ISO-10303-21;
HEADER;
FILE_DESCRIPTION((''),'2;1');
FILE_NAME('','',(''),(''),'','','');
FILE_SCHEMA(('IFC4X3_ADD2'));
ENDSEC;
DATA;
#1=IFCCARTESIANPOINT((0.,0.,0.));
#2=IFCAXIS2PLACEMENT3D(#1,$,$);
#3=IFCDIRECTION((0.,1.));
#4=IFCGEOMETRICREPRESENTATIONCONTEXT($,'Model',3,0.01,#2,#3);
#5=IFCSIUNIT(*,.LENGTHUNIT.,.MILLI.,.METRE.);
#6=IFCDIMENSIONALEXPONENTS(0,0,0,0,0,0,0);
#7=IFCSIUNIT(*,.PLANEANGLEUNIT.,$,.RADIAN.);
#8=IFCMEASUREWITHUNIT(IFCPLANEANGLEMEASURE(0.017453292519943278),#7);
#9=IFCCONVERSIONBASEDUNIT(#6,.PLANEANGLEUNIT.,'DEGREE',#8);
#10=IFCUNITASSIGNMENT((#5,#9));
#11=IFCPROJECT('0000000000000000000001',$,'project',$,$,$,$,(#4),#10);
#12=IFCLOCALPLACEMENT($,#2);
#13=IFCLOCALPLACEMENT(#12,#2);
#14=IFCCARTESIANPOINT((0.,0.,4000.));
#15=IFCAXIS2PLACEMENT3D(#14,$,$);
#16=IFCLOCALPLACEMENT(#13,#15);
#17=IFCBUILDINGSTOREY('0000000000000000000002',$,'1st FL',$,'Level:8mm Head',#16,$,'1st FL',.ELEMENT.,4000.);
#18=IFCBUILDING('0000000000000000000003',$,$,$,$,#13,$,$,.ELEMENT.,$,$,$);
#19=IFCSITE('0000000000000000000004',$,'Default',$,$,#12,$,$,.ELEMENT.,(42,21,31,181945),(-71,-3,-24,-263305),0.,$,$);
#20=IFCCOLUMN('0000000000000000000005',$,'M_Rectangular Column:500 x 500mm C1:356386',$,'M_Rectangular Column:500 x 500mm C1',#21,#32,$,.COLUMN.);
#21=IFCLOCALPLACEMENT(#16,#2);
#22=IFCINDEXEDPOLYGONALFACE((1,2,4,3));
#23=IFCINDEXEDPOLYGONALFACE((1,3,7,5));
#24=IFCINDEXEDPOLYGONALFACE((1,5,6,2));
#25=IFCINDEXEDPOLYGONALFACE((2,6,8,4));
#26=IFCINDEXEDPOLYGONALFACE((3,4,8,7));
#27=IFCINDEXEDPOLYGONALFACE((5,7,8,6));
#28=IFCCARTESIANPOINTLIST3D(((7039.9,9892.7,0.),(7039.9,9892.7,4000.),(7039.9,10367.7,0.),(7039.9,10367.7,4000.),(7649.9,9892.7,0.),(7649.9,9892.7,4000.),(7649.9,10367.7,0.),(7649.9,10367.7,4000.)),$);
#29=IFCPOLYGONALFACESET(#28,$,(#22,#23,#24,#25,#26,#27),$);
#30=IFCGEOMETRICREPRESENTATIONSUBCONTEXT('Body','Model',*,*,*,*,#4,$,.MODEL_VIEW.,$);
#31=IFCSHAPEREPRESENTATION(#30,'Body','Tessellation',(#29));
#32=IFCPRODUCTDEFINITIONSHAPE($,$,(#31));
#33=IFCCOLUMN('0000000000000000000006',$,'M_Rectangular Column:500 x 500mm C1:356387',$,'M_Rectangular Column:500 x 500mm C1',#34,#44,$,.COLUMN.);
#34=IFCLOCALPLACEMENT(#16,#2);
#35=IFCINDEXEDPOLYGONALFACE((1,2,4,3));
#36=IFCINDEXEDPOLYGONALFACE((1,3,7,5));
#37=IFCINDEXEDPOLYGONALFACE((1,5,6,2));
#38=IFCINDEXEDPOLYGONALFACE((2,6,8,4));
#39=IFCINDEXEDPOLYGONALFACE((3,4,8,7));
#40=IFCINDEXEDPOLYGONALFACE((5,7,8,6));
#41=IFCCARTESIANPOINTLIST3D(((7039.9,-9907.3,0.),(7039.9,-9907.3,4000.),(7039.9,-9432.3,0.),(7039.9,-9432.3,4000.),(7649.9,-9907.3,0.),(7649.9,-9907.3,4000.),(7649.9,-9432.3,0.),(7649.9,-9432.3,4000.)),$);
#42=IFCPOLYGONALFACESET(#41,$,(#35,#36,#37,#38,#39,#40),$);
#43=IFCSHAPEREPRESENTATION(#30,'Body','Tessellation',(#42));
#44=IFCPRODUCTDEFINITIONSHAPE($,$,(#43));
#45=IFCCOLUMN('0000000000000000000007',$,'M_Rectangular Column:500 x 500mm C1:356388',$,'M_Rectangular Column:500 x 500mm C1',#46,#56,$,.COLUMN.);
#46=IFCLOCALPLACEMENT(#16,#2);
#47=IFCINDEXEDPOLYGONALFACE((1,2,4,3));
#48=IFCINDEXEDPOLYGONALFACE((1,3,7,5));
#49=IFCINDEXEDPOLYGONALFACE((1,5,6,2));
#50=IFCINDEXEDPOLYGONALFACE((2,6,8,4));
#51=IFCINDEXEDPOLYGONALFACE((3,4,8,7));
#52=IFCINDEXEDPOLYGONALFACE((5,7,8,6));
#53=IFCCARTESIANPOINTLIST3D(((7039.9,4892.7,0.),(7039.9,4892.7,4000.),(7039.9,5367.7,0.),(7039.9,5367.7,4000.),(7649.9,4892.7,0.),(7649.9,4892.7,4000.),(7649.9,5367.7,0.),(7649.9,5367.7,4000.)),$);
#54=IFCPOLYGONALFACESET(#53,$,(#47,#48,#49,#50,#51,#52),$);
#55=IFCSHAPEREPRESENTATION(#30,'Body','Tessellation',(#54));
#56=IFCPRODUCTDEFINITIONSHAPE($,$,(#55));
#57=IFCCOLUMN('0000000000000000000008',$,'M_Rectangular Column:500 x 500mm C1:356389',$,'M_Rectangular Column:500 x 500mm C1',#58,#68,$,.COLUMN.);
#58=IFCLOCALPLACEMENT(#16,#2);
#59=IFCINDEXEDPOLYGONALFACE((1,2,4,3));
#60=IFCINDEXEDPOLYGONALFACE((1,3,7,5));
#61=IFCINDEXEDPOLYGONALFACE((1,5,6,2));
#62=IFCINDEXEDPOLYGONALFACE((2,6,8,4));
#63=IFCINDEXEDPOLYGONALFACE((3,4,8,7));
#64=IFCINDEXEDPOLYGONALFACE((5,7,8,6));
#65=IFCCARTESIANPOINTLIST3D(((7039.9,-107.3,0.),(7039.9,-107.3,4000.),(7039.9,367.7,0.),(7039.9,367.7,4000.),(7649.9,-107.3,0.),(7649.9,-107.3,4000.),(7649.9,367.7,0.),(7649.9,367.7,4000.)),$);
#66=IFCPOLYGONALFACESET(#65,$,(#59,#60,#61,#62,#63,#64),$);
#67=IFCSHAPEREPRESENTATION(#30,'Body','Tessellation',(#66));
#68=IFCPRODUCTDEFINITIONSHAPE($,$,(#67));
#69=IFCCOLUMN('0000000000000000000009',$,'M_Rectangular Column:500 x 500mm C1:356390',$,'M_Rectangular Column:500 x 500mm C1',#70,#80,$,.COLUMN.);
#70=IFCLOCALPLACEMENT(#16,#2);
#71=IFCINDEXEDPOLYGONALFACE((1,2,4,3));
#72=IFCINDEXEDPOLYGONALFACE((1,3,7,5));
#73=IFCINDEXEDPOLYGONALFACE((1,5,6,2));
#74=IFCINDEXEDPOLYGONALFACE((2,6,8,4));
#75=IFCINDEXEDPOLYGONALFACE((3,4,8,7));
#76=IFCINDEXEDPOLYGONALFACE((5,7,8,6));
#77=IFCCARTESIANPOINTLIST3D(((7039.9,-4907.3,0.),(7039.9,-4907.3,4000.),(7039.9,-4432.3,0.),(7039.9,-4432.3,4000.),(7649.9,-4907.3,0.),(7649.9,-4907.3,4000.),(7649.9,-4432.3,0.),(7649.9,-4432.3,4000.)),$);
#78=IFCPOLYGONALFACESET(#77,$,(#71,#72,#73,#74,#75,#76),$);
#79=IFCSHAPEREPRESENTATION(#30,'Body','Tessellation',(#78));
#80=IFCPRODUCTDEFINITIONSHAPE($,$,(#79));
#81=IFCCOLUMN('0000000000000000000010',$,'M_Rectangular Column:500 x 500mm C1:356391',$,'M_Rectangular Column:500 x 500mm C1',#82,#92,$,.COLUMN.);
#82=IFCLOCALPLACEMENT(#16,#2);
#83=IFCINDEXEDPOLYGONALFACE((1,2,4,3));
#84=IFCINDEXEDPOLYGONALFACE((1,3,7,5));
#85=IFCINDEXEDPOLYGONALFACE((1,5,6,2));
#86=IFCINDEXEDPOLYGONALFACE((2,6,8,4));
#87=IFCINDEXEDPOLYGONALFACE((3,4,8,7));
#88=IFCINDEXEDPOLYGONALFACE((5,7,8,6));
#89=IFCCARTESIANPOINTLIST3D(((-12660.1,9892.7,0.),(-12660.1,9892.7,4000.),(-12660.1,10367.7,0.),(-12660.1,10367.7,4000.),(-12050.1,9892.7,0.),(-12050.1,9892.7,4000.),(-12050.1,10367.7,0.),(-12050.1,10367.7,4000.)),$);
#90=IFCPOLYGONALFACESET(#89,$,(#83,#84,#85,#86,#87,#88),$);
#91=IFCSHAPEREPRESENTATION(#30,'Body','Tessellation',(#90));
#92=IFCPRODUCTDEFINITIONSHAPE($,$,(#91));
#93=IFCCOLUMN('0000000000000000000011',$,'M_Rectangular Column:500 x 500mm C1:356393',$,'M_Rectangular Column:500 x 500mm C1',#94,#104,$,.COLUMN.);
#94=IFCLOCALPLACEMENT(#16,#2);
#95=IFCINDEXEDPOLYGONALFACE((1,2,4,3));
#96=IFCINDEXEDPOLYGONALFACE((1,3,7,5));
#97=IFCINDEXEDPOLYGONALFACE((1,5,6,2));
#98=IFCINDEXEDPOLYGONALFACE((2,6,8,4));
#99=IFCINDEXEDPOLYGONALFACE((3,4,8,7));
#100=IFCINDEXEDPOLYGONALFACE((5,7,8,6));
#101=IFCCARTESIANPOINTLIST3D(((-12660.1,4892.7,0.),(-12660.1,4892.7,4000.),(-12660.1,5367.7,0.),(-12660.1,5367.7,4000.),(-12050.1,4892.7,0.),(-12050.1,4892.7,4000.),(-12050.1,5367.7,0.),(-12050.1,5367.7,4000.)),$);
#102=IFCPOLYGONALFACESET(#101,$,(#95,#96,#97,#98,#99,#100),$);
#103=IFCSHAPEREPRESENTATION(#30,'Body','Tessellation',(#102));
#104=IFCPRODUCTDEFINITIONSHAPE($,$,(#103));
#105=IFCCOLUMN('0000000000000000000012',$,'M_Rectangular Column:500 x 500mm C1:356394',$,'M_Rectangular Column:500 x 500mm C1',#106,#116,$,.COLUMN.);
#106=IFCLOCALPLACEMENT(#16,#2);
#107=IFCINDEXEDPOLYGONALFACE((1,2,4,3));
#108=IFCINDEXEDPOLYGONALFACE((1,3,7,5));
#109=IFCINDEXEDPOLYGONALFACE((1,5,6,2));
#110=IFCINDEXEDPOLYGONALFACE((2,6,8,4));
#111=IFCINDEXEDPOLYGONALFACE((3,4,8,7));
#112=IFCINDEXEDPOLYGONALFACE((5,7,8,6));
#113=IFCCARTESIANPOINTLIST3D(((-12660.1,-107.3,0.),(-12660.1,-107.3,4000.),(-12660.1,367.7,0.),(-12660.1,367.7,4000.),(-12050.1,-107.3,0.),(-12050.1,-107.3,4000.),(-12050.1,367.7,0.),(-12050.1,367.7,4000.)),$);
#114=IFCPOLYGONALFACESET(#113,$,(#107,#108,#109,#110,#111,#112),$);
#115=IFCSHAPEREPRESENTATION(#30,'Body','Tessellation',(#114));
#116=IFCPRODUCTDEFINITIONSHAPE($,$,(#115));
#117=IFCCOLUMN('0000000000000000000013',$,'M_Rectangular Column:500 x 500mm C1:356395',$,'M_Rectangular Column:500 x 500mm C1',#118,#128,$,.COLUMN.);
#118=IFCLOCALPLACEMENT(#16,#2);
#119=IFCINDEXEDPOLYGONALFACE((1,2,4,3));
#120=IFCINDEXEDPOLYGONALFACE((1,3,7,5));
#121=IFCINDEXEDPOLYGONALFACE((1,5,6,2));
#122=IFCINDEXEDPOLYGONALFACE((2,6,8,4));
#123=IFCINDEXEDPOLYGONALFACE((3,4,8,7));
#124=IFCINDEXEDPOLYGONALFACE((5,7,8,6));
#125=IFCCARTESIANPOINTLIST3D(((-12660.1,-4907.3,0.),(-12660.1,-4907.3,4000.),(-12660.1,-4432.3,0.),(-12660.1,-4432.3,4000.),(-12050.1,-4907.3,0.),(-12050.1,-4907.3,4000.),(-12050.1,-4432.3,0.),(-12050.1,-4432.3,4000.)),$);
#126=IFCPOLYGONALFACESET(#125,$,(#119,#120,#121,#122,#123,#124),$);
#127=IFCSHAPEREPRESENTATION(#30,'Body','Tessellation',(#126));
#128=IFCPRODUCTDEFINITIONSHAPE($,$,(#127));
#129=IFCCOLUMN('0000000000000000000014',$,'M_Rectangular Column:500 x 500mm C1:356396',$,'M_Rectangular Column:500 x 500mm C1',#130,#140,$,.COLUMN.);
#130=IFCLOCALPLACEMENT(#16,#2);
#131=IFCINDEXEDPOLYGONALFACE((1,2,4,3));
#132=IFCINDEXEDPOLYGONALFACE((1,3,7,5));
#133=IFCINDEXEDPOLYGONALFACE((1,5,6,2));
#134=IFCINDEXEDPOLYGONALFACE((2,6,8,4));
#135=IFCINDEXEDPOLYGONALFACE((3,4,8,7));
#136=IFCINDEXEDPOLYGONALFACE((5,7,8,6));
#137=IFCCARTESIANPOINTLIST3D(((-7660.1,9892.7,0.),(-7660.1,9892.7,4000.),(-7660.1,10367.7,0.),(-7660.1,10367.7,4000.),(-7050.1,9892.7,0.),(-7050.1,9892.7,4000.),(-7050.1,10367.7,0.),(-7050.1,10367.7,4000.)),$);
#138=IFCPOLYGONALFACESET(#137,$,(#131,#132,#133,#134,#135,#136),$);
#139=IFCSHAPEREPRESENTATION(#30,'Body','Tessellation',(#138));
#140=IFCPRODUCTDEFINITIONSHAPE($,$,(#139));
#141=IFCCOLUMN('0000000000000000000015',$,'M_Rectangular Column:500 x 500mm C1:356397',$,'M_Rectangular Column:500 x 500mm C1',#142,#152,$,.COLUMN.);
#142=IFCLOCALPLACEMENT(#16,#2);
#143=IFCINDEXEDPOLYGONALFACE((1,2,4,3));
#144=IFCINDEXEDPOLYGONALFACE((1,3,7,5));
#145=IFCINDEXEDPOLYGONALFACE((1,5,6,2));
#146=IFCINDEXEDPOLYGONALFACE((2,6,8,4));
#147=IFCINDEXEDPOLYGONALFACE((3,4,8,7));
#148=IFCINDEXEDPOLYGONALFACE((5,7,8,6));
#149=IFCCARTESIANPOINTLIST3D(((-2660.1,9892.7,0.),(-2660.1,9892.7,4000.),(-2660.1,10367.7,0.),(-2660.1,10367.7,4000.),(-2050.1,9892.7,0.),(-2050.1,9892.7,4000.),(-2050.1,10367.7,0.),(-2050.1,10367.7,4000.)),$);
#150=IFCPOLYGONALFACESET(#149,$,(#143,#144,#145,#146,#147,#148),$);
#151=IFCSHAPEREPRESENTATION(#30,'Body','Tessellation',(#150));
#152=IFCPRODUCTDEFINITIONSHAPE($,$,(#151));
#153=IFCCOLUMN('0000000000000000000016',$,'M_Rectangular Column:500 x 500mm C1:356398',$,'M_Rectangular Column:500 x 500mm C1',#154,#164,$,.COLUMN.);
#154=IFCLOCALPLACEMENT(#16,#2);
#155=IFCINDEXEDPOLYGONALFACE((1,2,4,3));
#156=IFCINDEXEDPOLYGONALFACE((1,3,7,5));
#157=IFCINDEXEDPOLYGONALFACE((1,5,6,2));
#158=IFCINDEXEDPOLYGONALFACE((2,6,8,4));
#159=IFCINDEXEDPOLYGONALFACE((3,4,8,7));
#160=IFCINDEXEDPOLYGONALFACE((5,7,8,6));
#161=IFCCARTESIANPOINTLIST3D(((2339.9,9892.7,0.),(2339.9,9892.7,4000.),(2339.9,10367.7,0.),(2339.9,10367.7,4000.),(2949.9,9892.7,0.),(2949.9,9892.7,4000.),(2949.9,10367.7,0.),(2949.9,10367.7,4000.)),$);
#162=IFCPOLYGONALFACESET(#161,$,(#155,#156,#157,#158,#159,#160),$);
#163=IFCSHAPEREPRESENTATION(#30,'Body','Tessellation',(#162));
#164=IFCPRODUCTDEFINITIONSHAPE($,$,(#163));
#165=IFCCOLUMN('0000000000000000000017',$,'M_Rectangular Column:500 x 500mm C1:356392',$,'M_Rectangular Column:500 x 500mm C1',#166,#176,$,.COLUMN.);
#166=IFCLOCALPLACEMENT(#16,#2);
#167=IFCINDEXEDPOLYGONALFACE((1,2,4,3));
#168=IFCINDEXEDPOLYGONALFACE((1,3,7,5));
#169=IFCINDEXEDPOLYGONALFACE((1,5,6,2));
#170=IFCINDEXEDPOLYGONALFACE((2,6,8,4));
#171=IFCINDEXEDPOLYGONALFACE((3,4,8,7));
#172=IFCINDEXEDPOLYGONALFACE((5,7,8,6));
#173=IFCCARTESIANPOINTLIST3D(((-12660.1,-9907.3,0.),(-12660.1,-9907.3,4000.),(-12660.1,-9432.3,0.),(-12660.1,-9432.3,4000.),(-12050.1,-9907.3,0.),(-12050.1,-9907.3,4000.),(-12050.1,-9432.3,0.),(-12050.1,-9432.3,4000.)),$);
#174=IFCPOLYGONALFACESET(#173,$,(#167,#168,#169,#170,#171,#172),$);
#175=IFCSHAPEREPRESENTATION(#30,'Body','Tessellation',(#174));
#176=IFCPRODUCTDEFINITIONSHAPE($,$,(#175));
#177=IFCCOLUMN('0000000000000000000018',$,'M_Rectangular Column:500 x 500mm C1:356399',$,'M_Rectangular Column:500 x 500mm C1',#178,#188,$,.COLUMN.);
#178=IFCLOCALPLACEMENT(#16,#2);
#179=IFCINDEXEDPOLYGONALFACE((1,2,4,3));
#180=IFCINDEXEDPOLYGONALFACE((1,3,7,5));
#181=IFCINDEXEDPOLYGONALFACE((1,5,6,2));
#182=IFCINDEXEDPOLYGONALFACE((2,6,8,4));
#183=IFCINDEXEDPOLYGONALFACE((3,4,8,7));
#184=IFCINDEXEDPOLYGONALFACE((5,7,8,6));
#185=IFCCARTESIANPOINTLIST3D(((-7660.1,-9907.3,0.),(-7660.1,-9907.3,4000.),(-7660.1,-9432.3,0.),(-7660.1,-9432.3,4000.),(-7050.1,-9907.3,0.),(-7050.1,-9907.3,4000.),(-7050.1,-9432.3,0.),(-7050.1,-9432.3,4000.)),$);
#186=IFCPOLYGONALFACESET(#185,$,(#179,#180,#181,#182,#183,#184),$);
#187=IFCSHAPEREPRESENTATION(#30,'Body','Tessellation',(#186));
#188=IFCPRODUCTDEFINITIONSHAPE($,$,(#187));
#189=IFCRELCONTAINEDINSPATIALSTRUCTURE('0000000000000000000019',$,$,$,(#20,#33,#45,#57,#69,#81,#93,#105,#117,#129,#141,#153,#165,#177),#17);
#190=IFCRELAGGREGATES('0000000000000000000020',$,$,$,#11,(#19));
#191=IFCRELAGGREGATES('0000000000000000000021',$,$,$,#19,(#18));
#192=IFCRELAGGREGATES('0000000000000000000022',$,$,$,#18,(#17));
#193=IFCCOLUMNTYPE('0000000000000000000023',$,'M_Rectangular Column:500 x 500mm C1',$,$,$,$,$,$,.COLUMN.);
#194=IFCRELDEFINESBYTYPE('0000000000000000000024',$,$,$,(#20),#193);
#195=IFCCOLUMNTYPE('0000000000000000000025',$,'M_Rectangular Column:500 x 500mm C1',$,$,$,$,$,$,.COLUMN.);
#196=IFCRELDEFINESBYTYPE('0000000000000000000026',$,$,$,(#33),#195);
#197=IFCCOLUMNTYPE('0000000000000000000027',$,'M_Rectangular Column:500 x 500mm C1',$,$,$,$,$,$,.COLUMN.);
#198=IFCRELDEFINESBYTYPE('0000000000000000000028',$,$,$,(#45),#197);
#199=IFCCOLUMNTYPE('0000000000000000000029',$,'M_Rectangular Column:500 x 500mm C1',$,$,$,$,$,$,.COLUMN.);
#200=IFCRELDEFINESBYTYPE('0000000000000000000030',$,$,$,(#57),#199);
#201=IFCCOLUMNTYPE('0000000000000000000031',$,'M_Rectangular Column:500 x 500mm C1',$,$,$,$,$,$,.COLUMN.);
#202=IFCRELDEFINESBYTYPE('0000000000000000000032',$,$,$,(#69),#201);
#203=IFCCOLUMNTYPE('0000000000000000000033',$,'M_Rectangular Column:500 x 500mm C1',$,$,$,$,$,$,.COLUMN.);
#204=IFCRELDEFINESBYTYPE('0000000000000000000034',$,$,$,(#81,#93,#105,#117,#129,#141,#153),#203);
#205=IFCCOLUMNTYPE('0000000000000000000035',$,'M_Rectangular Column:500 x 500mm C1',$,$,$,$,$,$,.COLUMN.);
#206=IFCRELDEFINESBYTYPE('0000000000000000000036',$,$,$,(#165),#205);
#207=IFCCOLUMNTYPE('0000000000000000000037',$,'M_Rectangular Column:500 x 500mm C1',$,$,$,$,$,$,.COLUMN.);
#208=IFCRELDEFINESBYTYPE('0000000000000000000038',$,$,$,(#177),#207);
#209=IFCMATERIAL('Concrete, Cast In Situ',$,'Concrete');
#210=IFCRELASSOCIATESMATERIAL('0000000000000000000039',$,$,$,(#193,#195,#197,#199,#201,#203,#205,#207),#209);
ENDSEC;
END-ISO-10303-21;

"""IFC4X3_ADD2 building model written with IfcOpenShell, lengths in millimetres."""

from ifc_helpers import new_model, entity, si_unit, converted_unit, direction, frame, frame_2d, origin, origin_2d_with_axis, place, context, subcontext, project, spatial, rectangle, extrude, source, transform, mapped, material, material_profile, profile_set, type_object, type_shapes, element, save


model = new_model("IFC4X3_ADD2")

# Units and contexts
model_context = context("Model", 3, precision=0.01, world=origin(), true_north=direction((0.0, 1.0)))
body_context = subcontext(model_context, "Body", "Model", "MODEL_VIEW")
ifc_project = project(units=[si_unit("LENGTHUNIT", "METRE", prefix="MILLI"), converted_unit("PLANEANGLEUNIT", "DEGREE", entity("IfcPlaneAngleMeasure", 0.017453292519943278), si_unit("PLANEANGLEUNIT", "RADIAN"), dimensions=[0, 0, 0, 0, 0, 0, 0])], contexts=[model_context])

# Site, building, storey
site_placement = place(None, origin())
site = spatial("IfcSite", under=ifc_project, at=site_placement, Name="Default", CompositionType="ELEMENT", RefLatitude=(42, 21, 31, 181945), RefLongitude=(-71, -3, -24, -263305), RefElevation=0.0)
building_placement = place(site_placement, origin())
building = spatial("IfcBuilding", under=site, at=building_placement, CompositionType="ELEMENT")
storey_placement = place(building_placement, frame((0.0, 0.0, 4000.0)))
storey = spatial("IfcBuildingStorey", under=building, at=storey_placement, Name="1st FL", ObjectType="Level:8mm Head", LongName="1st FL", CompositionType="ELEMENT", Elevation=4000.0)

# Columns
ifc_material_1 = material(Name="Concrete, Cast In Situ", Category="Concrete")
ifc_material_profile_1 = material_profile(ifc_material_1, rectangle(XDim=610.0, YDim=475.0, at=frame_2d((0.0, 0.0), x_axis=(1.0, 0.0))), Name="500 x 500mm C1")
ifc_profile_set_1 = profile_set([ifc_material_profile_1], Name="500 x 500mm C1")
column_type_1 = type_object("IfcColumnType", Name="M_Rectangular Column:500 x 500mm C1", PredefinedType="COLUMN", material=ifc_profile_set_1)
shared_shape_1 = source(origin(), body_context, "Body", "SweptSolid", [
    extrude(rectangle(XDim=610.0, YDim=475.0, at=frame_2d((0.0, 0.0), x_axis=(1.0, 0.0))), frame((7344.9, 10130.2, 4000.0), z_axis=(0.0, 0.0, 1.0), x_axis=(-1.0, 0.0, 0.0)), (0.0, 0.0, 1.0), 4000.0),
])
type_shapes(column_type_1, [shared_shape_1])
column_1_placement = place(storey_placement, frame((0.0, 0.0, -4000.0)))
element("IfcColumn", 1, at=column_1_placement, inside=storey, type_object=column_type_1, Name="M_Rectangular Column:500 x 500mm C1:356386", ObjectType="M_Rectangular Column:500 x 500mm C1", PredefinedType="COLUMN", context=body_context, shape_type="MappedRepresentation", body=[
    mapped(shared_shape_1, transform((0.0, 0.0, 0.0), scale=1.0)),
])
column_type_2 = type_object("IfcColumnType", Name="M_Rectangular Column:500 x 500mm C1", PredefinedType="COLUMN", material=ifc_profile_set_1)
shared_shape_2 = source(origin(), body_context, "Body", "SweptSolid", [
    extrude(rectangle(XDim=610.0, YDim=475.0, at=origin_2d_with_axis()), frame((7344.9, -9669.8, 4000.0), z_axis=(0.0, 0.0, 1.0), x_axis=(-1.0, 0.0, 0.0)), (0.0, 0.0, 1.0), 4000.0),
])
type_shapes(column_type_2, [shared_shape_2])
column_2_placement = place(storey_placement, frame((0.0, 0.0, -4000.0)))
element("IfcColumn", 2, at=column_2_placement, inside=storey, type_object=column_type_2, Name="M_Rectangular Column:500 x 500mm C1:356387", ObjectType="M_Rectangular Column:500 x 500mm C1", PredefinedType="COLUMN", context=body_context, shape_type="MappedRepresentation", body=[
    mapped(shared_shape_2, transform((0.0, 0.0, 0.0), scale=1.0)),
])
column_type_3 = type_object("IfcColumnType", Name="M_Rectangular Column:500 x 500mm C1", PredefinedType="COLUMN", material=ifc_profile_set_1)
shared_shape_3 = source(origin(), body_context, "Body", "SweptSolid", [
    extrude(rectangle(XDim=610.0, YDim=475.0, at=frame_2d((0.0, 0.0), x_axis=(1.0, 0.0))), frame((7344.9, 5130.2, 4000.0), z_axis=(0.0, 0.0, 1.0), x_axis=(-1.0, 0.0, 0.0)), (0.0, 0.0, 1.0), 4000.0),
])
type_shapes(column_type_3, [shared_shape_3])
column_3_placement = place(storey_placement, frame((0.0, 0.0, -4000.0)))
element("IfcColumn", 3, at=column_3_placement, inside=storey, type_object=column_type_3, Name="M_Rectangular Column:500 x 500mm C1:356388", ObjectType="M_Rectangular Column:500 x 500mm C1", PredefinedType="COLUMN", context=body_context, shape_type="MappedRepresentation", body=[
    mapped(shared_shape_3, transform((0.0, 0.0, 0.0), scale=1.0)),
])
column_type_4 = type_object("IfcColumnType", Name="M_Rectangular Column:500 x 500mm C1", PredefinedType="COLUMN", material=ifc_profile_set_1)
shared_shape_4 = source(origin(), body_context, "Body", "SweptSolid", [
    extrude(rectangle(XDim=610.0, YDim=475.0, at=origin_2d_with_axis()), frame((7344.9, 130.2, 4000.0), z_axis=(0.0, 0.0, 1.0), x_axis=(-1.0, 0.0, 0.0)), (0.0, 0.0, 1.0), 4000.0),
])
type_shapes(column_type_4, [shared_shape_4])
column_4_placement = place(storey_placement, frame((0.0, 0.0, -4000.0)))
element("IfcColumn", 4, at=column_4_placement, inside=storey, type_object=column_type_4, Name="M_Rectangular Column:500 x 500mm C1:356389", ObjectType="M_Rectangular Column:500 x 500mm C1", PredefinedType="COLUMN", context=body_context, shape_type="MappedRepresentation", body=[
    mapped(shared_shape_4, transform((0.0, 0.0, 0.0), scale=1.0)),
])
column_type_5 = type_object("IfcColumnType", Name="M_Rectangular Column:500 x 500mm C1", PredefinedType="COLUMN", material=ifc_profile_set_1)
shared_shape_5 = source(origin(), body_context, "Body", "SweptSolid", [
    extrude(rectangle(XDim=610.0, YDim=475.0, at=origin_2d_with_axis()), frame((7344.9, -4669.8, 4000.0), z_axis=(0.0, 0.0, 1.0), x_axis=(-1.0, 0.0, 0.0)), (0.0, 0.0, 1.0), 4000.0),
])
type_shapes(column_type_5, [shared_shape_5])
column_5_placement = place(storey_placement, frame((0.0, 0.0, -4000.0)))
element("IfcColumn", 5, at=column_5_placement, inside=storey, type_object=column_type_5, Name="M_Rectangular Column:500 x 500mm C1:356390", ObjectType="M_Rectangular Column:500 x 500mm C1", PredefinedType="COLUMN", context=body_context, shape_type="MappedRepresentation", body=[
    mapped(shared_shape_5, transform((0.0, 0.0, 0.0), scale=1.0)),
])
column_type_6 = type_object("IfcColumnType", Name="M_Rectangular Column:500 x 500mm C1", PredefinedType="COLUMN", material=ifc_profile_set_1)
shared_shape_6 = source(origin(), body_context, "Body", "SweptSolid", [
    extrude(rectangle(XDim=610.0, YDim=475.0, at=origin_2d_with_axis()), frame((0.0, 0.0, 4000.0), z_axis=(0.0, 0.0, 1.0), x_axis=(-1.0, 0.0, 0.0)), (0.0, 0.0, 1.0), 4000.0),
])
type_shapes(column_type_6, [shared_shape_6])
for number, where, name in (
    (6, (-12355.1, 10130.2, -4000.0), "M_Rectangular Column:500 x 500mm C1:356391"),
    (7, (-12355.1, 5130.2, -4000.0), "M_Rectangular Column:500 x 500mm C1:356393"),
    (8, (-12355.1, 130.2, -4000.0), "M_Rectangular Column:500 x 500mm C1:356394"),
    (9, (-12355.1, -4669.8, -4000.0), "M_Rectangular Column:500 x 500mm C1:356395"),
    (10, (-7355.1, 10130.2, -4000.0), "M_Rectangular Column:500 x 500mm C1:356396"),
    (11, (-2355.1, 10130.2, -4000.0), "M_Rectangular Column:500 x 500mm C1:356397"),
    (12, (2644.9, 10130.2, -4000.0), "M_Rectangular Column:500 x 500mm C1:356398"),
):
    element("IfcColumn", number, at=place(storey_placement, frame(where)), inside=storey, type_object=column_type_6, Name=name, ObjectType="M_Rectangular Column:500 x 500mm C1", PredefinedType="COLUMN", context=body_context, shape_type="MappedRepresentation", body=[
        mapped(shared_shape_6, transform((0.0, 0.0, 0.0), scale=1.0)),
    ])
column_type_7 = type_object("IfcColumnType", Name="M_Rectangular Column:500 x 500mm C1", PredefinedType="COLUMN", material=ifc_profile_set_1)
shared_shape_7 = source(origin(), body_context, "Body", "SweptSolid", [
    extrude(rectangle(XDim=610.0, YDim=475.0, at=frame_2d((0.0, 0.0), x_axis=(1.0, 0.0))), frame((-12355.1, -9669.8, 4000.0), z_axis=(0.0, 0.0, 1.0), x_axis=(-1.0, 0.0, 0.0)), (0.0, 0.0, 1.0), 4000.0),
])
type_shapes(column_type_7, [shared_shape_7])
column_6_placement = place(storey_placement, frame((0.0, 0.0, -4000.0)))
element("IfcColumn", 13, at=column_6_placement, inside=storey, type_object=column_type_7, Name="M_Rectangular Column:500 x 500mm C1:356392", ObjectType="M_Rectangular Column:500 x 500mm C1", PredefinedType="COLUMN", context=body_context, shape_type="MappedRepresentation", body=[
    mapped(shared_shape_7, transform((0.0, 0.0, 0.0), scale=1.0)),
])
column_type_8 = type_object("IfcColumnType", Name="M_Rectangular Column:500 x 500mm C1", PredefinedType="COLUMN", material=ifc_profile_set_1)
shared_shape_8 = source(origin(), body_context, "Body", "SweptSolid", [
    extrude(rectangle(XDim=610.0, YDim=475.0, at=origin_2d_with_axis()), frame((-7355.1, -9669.8, 4000.0), z_axis=(0.0, 0.0, 1.0), x_axis=(-1.0, 0.0, 0.0)), (0.0, 0.0, 1.0), 4000.0),
])
type_shapes(column_type_8, [shared_shape_8])
column_7_placement = place(storey_placement, frame((0.0, 0.0, -4000.0)))
element("IfcColumn", 14, at=column_7_placement, inside=storey, type_object=column_type_8, Name="M_Rectangular Column:500 x 500mm C1:356399", ObjectType="M_Rectangular Column:500 x 500mm C1", PredefinedType="COLUMN", context=body_context, shape_type="MappedRepresentation", body=[
    mapped(shared_shape_8, transform((0.0, 0.0, 0.0), scale=1.0)),
])

save(model, "model.ifc")
